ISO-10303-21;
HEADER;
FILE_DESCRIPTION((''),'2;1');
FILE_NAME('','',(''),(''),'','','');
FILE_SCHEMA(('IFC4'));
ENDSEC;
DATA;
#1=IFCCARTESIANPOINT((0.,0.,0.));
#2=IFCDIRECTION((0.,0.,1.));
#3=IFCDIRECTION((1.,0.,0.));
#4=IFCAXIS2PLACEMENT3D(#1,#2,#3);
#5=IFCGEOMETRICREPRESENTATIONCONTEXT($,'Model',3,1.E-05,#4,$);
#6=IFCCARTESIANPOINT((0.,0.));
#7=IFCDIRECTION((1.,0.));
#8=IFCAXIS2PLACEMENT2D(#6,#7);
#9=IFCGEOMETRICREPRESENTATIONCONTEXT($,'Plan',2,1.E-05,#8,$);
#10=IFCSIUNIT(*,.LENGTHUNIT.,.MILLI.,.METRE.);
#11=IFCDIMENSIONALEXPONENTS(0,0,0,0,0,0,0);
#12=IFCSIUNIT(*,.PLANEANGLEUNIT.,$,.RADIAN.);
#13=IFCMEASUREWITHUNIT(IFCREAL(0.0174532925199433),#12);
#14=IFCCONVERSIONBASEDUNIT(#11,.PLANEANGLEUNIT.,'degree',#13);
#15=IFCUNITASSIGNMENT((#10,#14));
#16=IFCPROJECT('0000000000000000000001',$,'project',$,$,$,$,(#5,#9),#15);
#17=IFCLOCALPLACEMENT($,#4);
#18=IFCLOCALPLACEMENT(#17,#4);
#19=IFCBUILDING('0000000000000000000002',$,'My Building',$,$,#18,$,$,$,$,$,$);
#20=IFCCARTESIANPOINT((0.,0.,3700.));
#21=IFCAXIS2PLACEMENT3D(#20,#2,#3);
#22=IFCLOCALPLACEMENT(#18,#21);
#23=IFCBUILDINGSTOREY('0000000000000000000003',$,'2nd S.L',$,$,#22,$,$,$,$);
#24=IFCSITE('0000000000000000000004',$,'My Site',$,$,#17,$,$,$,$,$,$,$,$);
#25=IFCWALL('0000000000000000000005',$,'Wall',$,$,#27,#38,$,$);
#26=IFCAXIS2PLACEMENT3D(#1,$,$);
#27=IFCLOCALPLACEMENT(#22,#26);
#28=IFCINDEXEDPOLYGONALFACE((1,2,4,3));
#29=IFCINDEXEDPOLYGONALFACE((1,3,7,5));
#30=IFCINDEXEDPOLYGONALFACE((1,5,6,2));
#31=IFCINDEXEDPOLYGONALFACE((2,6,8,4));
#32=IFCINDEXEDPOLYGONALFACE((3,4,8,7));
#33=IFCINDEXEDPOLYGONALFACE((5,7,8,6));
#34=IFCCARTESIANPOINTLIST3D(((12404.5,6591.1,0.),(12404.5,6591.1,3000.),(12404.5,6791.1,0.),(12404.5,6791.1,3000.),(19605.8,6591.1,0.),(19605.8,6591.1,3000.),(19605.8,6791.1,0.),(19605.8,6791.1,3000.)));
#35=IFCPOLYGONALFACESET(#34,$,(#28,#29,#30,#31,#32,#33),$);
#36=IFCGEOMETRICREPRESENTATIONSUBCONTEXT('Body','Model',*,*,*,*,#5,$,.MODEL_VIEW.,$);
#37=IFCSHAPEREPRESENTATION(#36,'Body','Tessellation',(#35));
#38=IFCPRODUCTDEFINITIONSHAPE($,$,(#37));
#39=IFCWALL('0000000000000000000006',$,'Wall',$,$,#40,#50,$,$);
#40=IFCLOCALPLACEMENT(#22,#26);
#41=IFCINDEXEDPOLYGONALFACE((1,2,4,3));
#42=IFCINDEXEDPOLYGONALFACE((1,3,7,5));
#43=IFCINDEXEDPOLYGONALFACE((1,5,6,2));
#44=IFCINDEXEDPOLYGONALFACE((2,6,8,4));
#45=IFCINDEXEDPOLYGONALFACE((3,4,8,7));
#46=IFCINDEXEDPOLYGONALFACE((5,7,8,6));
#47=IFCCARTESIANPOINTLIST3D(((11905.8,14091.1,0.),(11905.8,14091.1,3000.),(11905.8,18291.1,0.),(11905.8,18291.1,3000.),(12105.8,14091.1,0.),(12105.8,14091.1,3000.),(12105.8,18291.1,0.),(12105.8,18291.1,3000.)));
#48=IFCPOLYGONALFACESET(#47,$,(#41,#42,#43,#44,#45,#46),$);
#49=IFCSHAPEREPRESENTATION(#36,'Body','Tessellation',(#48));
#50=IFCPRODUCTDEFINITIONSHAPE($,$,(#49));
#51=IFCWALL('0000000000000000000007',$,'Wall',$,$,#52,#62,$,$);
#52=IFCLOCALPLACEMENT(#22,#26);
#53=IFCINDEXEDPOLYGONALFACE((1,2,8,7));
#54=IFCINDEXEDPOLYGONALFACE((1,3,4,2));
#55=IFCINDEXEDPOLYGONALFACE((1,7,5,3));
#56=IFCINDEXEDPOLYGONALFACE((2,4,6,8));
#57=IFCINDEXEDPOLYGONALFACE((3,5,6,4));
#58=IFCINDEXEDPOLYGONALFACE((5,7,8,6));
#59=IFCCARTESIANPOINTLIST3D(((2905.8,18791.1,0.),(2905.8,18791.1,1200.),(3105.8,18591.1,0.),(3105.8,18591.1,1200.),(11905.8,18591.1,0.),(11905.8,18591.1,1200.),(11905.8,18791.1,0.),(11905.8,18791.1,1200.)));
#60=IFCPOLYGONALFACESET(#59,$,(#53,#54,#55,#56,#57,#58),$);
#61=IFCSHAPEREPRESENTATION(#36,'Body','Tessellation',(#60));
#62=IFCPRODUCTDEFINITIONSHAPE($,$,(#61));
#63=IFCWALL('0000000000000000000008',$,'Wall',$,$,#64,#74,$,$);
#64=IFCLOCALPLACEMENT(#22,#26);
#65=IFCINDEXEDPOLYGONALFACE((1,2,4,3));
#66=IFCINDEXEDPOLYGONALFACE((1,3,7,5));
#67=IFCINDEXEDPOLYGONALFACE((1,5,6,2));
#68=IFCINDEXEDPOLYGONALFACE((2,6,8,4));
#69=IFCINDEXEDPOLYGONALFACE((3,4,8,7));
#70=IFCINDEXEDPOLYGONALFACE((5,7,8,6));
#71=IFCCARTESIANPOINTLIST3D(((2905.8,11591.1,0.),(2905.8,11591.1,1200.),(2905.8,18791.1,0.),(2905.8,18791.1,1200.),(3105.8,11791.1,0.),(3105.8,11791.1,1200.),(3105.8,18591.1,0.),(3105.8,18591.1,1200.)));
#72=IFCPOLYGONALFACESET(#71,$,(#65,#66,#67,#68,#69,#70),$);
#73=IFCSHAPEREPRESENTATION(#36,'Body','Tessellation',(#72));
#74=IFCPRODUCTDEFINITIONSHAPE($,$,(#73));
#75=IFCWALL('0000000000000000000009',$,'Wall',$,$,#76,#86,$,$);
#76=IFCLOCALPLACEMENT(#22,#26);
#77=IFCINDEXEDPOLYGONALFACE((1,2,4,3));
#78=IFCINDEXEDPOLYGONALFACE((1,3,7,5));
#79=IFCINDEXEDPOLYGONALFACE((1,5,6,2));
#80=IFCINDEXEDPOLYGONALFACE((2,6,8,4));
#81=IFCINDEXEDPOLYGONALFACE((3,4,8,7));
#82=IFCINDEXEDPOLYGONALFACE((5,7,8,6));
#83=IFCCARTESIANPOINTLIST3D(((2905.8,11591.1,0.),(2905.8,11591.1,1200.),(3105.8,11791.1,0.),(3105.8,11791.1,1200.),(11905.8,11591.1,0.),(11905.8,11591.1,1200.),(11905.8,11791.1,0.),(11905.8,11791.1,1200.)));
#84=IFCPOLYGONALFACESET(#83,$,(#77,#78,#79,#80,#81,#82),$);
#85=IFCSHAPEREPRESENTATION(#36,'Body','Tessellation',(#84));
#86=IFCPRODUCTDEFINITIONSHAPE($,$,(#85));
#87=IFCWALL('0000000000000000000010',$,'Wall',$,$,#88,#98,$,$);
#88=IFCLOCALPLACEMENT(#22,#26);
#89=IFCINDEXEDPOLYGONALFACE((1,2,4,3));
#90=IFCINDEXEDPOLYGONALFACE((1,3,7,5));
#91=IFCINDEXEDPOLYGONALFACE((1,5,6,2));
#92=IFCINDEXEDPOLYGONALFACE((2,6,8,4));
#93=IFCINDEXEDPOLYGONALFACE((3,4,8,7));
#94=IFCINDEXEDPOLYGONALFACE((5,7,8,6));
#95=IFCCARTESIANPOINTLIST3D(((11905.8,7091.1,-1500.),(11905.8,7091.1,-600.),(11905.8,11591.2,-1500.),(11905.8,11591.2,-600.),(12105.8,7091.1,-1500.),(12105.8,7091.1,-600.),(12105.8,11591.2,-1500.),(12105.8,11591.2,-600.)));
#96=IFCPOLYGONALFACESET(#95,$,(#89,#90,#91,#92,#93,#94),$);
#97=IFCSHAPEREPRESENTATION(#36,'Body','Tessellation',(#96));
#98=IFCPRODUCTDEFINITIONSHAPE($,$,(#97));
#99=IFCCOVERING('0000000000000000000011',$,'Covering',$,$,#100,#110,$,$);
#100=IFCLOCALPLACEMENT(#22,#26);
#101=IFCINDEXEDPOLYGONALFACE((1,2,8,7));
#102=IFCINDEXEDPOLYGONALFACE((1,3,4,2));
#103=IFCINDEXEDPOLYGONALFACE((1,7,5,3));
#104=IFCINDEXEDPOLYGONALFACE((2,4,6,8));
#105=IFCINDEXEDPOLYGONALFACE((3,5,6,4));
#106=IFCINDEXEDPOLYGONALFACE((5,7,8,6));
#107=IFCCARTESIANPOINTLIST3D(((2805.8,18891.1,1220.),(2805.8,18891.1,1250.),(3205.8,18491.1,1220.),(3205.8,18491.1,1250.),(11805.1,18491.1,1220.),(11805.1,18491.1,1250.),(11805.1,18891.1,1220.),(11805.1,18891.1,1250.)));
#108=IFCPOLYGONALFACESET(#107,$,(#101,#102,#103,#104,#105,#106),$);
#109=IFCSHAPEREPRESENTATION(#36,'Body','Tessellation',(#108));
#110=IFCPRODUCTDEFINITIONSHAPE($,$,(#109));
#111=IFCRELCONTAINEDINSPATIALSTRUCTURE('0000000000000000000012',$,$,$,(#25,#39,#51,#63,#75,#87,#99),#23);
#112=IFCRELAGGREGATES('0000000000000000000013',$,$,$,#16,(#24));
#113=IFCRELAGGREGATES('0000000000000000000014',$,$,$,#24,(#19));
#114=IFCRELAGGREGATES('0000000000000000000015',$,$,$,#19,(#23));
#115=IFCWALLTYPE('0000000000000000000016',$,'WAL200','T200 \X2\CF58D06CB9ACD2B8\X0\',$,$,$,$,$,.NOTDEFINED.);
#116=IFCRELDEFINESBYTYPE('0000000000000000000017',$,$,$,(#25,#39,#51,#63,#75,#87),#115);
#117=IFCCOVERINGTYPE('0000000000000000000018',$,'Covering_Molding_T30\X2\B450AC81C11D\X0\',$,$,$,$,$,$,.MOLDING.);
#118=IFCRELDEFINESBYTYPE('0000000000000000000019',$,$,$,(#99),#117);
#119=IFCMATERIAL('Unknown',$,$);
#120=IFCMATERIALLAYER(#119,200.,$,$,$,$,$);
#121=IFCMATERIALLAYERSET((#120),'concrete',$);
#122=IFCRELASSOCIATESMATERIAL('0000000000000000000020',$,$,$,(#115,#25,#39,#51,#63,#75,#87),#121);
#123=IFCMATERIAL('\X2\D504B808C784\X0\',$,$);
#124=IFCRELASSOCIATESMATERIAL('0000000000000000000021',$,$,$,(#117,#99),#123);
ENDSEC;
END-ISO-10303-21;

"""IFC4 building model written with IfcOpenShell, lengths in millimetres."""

from ifc_helpers import new_model, entity, si_unit, converted_unit, frame, origin_with_axes, origin_2d_with_axis, place, context, subcontext, project, spatial, indexed_curve, rectangle, outline, extrude, clip, halfspace, material, layer, layer_set, layer_usage, material_profile, profile_set, profile_usage, type_object, element, save


model = new_model("IFC4")

# Units and contexts
model_context = context("Model", 3, precision=1e-05, world=origin_with_axes())
plan_context = context("Plan", 2, precision=1e-05, world=origin_2d_with_axis())
body_context = subcontext(model_context, "Body", "Model", "MODEL_VIEW")
ifc_project = project(units=[si_unit("LENGTHUNIT", "METRE", prefix="MILLI"), converted_unit("PLANEANGLEUNIT", "degree", entity("IfcReal", 0.0174532925199433), si_unit("PLANEANGLEUNIT", "RADIAN"), dimensions=[0, 0, 0, 0, 0, 0, 0])], contexts=[model_context, plan_context])

# Site, building, storey
site_placement = place(None, origin_with_axes())
site = spatial("IfcSite", under=ifc_project, at=site_placement, Name="My Site")
building_placement = place(site_placement, origin_with_axes())
building = spatial("IfcBuilding", under=site, at=building_placement, Name="My Building")
storey_placement = place(building_placement, frame((0.0, 0.0, 3700.0), z_axis=(0.0, 0.0, 1.0), x_axis=(1.0, 0.0, 0.0)))
storey = spatial("IfcBuildingStorey", under=building, at=storey_placement, Name="2nd S.L")

# Shared definitions
ifc_material_1 = material(Name="Unknown")

# Walls
ifc_layer_1 = layer(ifc_material_1, 200.0)
ifc_layer_set_1 = layer_set([ifc_layer_1], Name="concrete")
wall_type = type_object("IfcWallType", Name="WAL200", Description="T200 콘크리트", PredefinedType="NOTDEFINED", material=ifc_layer_set_1)
ifc_layer_usage_1 = layer_usage(ifc_layer_set_1, "AXIS2", "POSITIVE", 0.0)
wall_1_placement = place(storey_placement, frame((12404.5, 6591.1, 0.0), z_axis=(0.0, 0.0, 1.0), x_axis=(1.0, 0.0, 0.0)))
element("IfcWall", 1, at=wall_1_placement, inside=storey, type_object=wall_type, material=ifc_layer_usage_1, Name="Wall", context=body_context, shape_type="SweptSolid", body=[
    extrude(outline(indexed_curve([(0.0, 0.0), (0.0, 200.0), (7201.4, 200.0), (7201.4, 0.0), (0.0, 0.0)], self_intersect=False)), origin_with_axes(), (0.0, 0.0, 1.0), 3000.0),
])
ifc_layer_usage_2 = layer_usage(ifc_layer_set_1, "AXIS2", "POSITIVE", 0.0)
wall_2_placement = place(storey_placement, frame((12105.8, 14091.1, 0.0), z_axis=(0.0, 0.0, 1.0), x_axis=(0.0, 1.0, 0.0)))
element("IfcWall", 2, at=wall_2_placement, inside=storey, type_object=wall_type, material=ifc_layer_usage_2, Name="Wall", context=body_context, shape_type="SweptSolid", body=[
    extrude(outline(indexed_curve([(0.0, 0.0), (0.0, 200.0), (4200.0, 200.0), (4200.0, 0.0), (0.0, 0.0)], self_intersect=False)), origin_with_axes(), (0.0, 0.0, 1.0), 3000.0),
])
ifc_layer_usage_3 = layer_usage(ifc_layer_set_1, "AXIS2", "POSITIVE", 0.0)
wall_3_placement = place(storey_placement, frame((11905.8, 18791.1, 0.0), z_axis=(0.0, 0.0, 1.0), x_axis=(-1.0, 0.0, 0.0)))
element("IfcWall", 3, at=wall_3_placement, inside=storey, type_object=wall_type, material=ifc_layer_usage_3, Name="Wall", context=body_context, shape_type="Clipping", body=[
    clip(extrude(outline(indexed_curve([(0.0, 0.0), (0.0, 200.0), (9000.0, 200.0), (9000.0, 0.0), (0.0, 0.0)], self_intersect=False)), origin_with_axes(), (0.0, 0.0, 1.0), 1200.0), halfspace(frame((9000.0, 0.0, -3700.0), z_axis=(0.707108, 0.707105, 0.0), x_axis=(0.707105, -0.707108, 0.0)), False)),
])
ifc_layer_usage_4 = layer_usage(ifc_layer_set_1, "AXIS2", "POSITIVE", 0.0)
wall_4_placement = place(storey_placement, frame((2905.8, 18791.1, 0.0), z_axis=(0.0, 0.0, 1.0), x_axis=(0.0, -1.0, 0.0)))
element("IfcWall", 4, at=wall_4_placement, inside=storey, type_object=wall_type, material=ifc_layer_usage_4, Name="Wall", context=body_context, shape_type="Clipping", body=[
    clip(clip(extrude(outline(indexed_curve([(0.0, 0.0), (0.0, 200.0), (7200.0, 200.0), (7200.0, 0.0), (0.0, 0.0)], self_intersect=False)), origin_with_axes(), (0.0, 0.0, 1.0), 1200.0), halfspace(frame((7200.0, 0.0, -3700.0), z_axis=(0.707107, 0.707106, 0.0), x_axis=(0.707106, -0.707107, 0.0)), False)), halfspace(frame((0.0, 0.0, -3700.0), z_axis=(-0.707106, 0.707108, 0.0), x_axis=(0.707108, 0.707106, 0.0)), False)),
])
ifc_layer_usage_5 = layer_usage(ifc_layer_set_1, "AXIS2", "POSITIVE", 0.0)
wall_5_placement = place(storey_placement, frame((2905.8, 11591.1, 0.0), z_axis=(0.0, 0.0, 1.0), x_axis=(1.0, 0.0, 0.0)))
element("IfcWall", 5, at=wall_5_placement, inside=storey, type_object=wall_type, material=ifc_layer_usage_5, Name="Wall", context=body_context, shape_type="Clipping", body=[
    clip(extrude(outline(indexed_curve([(0.0, 0.0), (0.0, 200.0), (9000.0, 200.0), (9000.0, 0.0), (0.0, 0.0)], self_intersect=False)), origin_with_axes(), (0.0, 0.0, 1.0), 1200.0), halfspace(frame((0.0, 0.0, -3700.0), z_axis=(-0.707106, 0.707108, 0.0), x_axis=(0.707108, 0.707106, 0.0)), False)),
])
ifc_layer_usage_6 = layer_usage(ifc_layer_set_1, "AXIS2", "POSITIVE", 0.0)
wall_6_placement = place(storey_placement, frame((12105.8, 7091.1, -1500.0), z_axis=(0.0, 0.0, 1.0), x_axis=(0.0, 1.0, 0.0)))
element("IfcWall", 6, at=wall_6_placement, inside=storey, type_object=wall_type, material=ifc_layer_usage_6, Name="Wall", context=body_context, shape_type="SweptSolid", body=[
    extrude(outline(indexed_curve([(0.0, 0.0), (0.0, 200.0), (4500.1, 200.0), (4500.1, 0.0), (0.0, 0.0)], self_intersect=False)), origin_with_axes(), (0.0, 0.0, 1.0), 900.0),
])

# Covering
ifc_material_2 = material(Name="프레임")
ifc_material_profile_1 = material_profile(ifc_material_2, rectangle(XDim=400.0, YDim=30.0, kind="CURVE"))
ifc_profile_set_1 = profile_set([ifc_material_profile_1])
ifc_profile_usage_1 = profile_usage(ifc_profile_set_1, cardinal=5)
covering_type = type_object("IfcCoveringType", Name="Covering_Molding_T30두겁석", PredefinedType="MOLDING", material=ifc_profile_set_1)
covering_placement = place(storey_placement, frame((2805.8, 18691.1, 1235.0), z_axis=(1.0, 0.0, 0.0), x_axis=(0.0, 1.0, 0.0)))
element("IfcCovering", 7, at=covering_placement, inside=storey, type_object=covering_type, material=ifc_profile_usage_1, Name="Covering", context=body_context, shape_type="Clipping", body=[
    clip(extrude(rectangle(XDim=400.0, YDim=30.0, kind="CURVE"), origin_with_axes(), (0.0, 0.0, 1.0), 8999.3), halfspace(frame((200.0, -4915.0, 0.0), z_axis=(-0.707106, 0.0, -0.707108), x_axis=(0.0, 1.0, 0.0)), False)),
])

save(model, "model.ifc")
